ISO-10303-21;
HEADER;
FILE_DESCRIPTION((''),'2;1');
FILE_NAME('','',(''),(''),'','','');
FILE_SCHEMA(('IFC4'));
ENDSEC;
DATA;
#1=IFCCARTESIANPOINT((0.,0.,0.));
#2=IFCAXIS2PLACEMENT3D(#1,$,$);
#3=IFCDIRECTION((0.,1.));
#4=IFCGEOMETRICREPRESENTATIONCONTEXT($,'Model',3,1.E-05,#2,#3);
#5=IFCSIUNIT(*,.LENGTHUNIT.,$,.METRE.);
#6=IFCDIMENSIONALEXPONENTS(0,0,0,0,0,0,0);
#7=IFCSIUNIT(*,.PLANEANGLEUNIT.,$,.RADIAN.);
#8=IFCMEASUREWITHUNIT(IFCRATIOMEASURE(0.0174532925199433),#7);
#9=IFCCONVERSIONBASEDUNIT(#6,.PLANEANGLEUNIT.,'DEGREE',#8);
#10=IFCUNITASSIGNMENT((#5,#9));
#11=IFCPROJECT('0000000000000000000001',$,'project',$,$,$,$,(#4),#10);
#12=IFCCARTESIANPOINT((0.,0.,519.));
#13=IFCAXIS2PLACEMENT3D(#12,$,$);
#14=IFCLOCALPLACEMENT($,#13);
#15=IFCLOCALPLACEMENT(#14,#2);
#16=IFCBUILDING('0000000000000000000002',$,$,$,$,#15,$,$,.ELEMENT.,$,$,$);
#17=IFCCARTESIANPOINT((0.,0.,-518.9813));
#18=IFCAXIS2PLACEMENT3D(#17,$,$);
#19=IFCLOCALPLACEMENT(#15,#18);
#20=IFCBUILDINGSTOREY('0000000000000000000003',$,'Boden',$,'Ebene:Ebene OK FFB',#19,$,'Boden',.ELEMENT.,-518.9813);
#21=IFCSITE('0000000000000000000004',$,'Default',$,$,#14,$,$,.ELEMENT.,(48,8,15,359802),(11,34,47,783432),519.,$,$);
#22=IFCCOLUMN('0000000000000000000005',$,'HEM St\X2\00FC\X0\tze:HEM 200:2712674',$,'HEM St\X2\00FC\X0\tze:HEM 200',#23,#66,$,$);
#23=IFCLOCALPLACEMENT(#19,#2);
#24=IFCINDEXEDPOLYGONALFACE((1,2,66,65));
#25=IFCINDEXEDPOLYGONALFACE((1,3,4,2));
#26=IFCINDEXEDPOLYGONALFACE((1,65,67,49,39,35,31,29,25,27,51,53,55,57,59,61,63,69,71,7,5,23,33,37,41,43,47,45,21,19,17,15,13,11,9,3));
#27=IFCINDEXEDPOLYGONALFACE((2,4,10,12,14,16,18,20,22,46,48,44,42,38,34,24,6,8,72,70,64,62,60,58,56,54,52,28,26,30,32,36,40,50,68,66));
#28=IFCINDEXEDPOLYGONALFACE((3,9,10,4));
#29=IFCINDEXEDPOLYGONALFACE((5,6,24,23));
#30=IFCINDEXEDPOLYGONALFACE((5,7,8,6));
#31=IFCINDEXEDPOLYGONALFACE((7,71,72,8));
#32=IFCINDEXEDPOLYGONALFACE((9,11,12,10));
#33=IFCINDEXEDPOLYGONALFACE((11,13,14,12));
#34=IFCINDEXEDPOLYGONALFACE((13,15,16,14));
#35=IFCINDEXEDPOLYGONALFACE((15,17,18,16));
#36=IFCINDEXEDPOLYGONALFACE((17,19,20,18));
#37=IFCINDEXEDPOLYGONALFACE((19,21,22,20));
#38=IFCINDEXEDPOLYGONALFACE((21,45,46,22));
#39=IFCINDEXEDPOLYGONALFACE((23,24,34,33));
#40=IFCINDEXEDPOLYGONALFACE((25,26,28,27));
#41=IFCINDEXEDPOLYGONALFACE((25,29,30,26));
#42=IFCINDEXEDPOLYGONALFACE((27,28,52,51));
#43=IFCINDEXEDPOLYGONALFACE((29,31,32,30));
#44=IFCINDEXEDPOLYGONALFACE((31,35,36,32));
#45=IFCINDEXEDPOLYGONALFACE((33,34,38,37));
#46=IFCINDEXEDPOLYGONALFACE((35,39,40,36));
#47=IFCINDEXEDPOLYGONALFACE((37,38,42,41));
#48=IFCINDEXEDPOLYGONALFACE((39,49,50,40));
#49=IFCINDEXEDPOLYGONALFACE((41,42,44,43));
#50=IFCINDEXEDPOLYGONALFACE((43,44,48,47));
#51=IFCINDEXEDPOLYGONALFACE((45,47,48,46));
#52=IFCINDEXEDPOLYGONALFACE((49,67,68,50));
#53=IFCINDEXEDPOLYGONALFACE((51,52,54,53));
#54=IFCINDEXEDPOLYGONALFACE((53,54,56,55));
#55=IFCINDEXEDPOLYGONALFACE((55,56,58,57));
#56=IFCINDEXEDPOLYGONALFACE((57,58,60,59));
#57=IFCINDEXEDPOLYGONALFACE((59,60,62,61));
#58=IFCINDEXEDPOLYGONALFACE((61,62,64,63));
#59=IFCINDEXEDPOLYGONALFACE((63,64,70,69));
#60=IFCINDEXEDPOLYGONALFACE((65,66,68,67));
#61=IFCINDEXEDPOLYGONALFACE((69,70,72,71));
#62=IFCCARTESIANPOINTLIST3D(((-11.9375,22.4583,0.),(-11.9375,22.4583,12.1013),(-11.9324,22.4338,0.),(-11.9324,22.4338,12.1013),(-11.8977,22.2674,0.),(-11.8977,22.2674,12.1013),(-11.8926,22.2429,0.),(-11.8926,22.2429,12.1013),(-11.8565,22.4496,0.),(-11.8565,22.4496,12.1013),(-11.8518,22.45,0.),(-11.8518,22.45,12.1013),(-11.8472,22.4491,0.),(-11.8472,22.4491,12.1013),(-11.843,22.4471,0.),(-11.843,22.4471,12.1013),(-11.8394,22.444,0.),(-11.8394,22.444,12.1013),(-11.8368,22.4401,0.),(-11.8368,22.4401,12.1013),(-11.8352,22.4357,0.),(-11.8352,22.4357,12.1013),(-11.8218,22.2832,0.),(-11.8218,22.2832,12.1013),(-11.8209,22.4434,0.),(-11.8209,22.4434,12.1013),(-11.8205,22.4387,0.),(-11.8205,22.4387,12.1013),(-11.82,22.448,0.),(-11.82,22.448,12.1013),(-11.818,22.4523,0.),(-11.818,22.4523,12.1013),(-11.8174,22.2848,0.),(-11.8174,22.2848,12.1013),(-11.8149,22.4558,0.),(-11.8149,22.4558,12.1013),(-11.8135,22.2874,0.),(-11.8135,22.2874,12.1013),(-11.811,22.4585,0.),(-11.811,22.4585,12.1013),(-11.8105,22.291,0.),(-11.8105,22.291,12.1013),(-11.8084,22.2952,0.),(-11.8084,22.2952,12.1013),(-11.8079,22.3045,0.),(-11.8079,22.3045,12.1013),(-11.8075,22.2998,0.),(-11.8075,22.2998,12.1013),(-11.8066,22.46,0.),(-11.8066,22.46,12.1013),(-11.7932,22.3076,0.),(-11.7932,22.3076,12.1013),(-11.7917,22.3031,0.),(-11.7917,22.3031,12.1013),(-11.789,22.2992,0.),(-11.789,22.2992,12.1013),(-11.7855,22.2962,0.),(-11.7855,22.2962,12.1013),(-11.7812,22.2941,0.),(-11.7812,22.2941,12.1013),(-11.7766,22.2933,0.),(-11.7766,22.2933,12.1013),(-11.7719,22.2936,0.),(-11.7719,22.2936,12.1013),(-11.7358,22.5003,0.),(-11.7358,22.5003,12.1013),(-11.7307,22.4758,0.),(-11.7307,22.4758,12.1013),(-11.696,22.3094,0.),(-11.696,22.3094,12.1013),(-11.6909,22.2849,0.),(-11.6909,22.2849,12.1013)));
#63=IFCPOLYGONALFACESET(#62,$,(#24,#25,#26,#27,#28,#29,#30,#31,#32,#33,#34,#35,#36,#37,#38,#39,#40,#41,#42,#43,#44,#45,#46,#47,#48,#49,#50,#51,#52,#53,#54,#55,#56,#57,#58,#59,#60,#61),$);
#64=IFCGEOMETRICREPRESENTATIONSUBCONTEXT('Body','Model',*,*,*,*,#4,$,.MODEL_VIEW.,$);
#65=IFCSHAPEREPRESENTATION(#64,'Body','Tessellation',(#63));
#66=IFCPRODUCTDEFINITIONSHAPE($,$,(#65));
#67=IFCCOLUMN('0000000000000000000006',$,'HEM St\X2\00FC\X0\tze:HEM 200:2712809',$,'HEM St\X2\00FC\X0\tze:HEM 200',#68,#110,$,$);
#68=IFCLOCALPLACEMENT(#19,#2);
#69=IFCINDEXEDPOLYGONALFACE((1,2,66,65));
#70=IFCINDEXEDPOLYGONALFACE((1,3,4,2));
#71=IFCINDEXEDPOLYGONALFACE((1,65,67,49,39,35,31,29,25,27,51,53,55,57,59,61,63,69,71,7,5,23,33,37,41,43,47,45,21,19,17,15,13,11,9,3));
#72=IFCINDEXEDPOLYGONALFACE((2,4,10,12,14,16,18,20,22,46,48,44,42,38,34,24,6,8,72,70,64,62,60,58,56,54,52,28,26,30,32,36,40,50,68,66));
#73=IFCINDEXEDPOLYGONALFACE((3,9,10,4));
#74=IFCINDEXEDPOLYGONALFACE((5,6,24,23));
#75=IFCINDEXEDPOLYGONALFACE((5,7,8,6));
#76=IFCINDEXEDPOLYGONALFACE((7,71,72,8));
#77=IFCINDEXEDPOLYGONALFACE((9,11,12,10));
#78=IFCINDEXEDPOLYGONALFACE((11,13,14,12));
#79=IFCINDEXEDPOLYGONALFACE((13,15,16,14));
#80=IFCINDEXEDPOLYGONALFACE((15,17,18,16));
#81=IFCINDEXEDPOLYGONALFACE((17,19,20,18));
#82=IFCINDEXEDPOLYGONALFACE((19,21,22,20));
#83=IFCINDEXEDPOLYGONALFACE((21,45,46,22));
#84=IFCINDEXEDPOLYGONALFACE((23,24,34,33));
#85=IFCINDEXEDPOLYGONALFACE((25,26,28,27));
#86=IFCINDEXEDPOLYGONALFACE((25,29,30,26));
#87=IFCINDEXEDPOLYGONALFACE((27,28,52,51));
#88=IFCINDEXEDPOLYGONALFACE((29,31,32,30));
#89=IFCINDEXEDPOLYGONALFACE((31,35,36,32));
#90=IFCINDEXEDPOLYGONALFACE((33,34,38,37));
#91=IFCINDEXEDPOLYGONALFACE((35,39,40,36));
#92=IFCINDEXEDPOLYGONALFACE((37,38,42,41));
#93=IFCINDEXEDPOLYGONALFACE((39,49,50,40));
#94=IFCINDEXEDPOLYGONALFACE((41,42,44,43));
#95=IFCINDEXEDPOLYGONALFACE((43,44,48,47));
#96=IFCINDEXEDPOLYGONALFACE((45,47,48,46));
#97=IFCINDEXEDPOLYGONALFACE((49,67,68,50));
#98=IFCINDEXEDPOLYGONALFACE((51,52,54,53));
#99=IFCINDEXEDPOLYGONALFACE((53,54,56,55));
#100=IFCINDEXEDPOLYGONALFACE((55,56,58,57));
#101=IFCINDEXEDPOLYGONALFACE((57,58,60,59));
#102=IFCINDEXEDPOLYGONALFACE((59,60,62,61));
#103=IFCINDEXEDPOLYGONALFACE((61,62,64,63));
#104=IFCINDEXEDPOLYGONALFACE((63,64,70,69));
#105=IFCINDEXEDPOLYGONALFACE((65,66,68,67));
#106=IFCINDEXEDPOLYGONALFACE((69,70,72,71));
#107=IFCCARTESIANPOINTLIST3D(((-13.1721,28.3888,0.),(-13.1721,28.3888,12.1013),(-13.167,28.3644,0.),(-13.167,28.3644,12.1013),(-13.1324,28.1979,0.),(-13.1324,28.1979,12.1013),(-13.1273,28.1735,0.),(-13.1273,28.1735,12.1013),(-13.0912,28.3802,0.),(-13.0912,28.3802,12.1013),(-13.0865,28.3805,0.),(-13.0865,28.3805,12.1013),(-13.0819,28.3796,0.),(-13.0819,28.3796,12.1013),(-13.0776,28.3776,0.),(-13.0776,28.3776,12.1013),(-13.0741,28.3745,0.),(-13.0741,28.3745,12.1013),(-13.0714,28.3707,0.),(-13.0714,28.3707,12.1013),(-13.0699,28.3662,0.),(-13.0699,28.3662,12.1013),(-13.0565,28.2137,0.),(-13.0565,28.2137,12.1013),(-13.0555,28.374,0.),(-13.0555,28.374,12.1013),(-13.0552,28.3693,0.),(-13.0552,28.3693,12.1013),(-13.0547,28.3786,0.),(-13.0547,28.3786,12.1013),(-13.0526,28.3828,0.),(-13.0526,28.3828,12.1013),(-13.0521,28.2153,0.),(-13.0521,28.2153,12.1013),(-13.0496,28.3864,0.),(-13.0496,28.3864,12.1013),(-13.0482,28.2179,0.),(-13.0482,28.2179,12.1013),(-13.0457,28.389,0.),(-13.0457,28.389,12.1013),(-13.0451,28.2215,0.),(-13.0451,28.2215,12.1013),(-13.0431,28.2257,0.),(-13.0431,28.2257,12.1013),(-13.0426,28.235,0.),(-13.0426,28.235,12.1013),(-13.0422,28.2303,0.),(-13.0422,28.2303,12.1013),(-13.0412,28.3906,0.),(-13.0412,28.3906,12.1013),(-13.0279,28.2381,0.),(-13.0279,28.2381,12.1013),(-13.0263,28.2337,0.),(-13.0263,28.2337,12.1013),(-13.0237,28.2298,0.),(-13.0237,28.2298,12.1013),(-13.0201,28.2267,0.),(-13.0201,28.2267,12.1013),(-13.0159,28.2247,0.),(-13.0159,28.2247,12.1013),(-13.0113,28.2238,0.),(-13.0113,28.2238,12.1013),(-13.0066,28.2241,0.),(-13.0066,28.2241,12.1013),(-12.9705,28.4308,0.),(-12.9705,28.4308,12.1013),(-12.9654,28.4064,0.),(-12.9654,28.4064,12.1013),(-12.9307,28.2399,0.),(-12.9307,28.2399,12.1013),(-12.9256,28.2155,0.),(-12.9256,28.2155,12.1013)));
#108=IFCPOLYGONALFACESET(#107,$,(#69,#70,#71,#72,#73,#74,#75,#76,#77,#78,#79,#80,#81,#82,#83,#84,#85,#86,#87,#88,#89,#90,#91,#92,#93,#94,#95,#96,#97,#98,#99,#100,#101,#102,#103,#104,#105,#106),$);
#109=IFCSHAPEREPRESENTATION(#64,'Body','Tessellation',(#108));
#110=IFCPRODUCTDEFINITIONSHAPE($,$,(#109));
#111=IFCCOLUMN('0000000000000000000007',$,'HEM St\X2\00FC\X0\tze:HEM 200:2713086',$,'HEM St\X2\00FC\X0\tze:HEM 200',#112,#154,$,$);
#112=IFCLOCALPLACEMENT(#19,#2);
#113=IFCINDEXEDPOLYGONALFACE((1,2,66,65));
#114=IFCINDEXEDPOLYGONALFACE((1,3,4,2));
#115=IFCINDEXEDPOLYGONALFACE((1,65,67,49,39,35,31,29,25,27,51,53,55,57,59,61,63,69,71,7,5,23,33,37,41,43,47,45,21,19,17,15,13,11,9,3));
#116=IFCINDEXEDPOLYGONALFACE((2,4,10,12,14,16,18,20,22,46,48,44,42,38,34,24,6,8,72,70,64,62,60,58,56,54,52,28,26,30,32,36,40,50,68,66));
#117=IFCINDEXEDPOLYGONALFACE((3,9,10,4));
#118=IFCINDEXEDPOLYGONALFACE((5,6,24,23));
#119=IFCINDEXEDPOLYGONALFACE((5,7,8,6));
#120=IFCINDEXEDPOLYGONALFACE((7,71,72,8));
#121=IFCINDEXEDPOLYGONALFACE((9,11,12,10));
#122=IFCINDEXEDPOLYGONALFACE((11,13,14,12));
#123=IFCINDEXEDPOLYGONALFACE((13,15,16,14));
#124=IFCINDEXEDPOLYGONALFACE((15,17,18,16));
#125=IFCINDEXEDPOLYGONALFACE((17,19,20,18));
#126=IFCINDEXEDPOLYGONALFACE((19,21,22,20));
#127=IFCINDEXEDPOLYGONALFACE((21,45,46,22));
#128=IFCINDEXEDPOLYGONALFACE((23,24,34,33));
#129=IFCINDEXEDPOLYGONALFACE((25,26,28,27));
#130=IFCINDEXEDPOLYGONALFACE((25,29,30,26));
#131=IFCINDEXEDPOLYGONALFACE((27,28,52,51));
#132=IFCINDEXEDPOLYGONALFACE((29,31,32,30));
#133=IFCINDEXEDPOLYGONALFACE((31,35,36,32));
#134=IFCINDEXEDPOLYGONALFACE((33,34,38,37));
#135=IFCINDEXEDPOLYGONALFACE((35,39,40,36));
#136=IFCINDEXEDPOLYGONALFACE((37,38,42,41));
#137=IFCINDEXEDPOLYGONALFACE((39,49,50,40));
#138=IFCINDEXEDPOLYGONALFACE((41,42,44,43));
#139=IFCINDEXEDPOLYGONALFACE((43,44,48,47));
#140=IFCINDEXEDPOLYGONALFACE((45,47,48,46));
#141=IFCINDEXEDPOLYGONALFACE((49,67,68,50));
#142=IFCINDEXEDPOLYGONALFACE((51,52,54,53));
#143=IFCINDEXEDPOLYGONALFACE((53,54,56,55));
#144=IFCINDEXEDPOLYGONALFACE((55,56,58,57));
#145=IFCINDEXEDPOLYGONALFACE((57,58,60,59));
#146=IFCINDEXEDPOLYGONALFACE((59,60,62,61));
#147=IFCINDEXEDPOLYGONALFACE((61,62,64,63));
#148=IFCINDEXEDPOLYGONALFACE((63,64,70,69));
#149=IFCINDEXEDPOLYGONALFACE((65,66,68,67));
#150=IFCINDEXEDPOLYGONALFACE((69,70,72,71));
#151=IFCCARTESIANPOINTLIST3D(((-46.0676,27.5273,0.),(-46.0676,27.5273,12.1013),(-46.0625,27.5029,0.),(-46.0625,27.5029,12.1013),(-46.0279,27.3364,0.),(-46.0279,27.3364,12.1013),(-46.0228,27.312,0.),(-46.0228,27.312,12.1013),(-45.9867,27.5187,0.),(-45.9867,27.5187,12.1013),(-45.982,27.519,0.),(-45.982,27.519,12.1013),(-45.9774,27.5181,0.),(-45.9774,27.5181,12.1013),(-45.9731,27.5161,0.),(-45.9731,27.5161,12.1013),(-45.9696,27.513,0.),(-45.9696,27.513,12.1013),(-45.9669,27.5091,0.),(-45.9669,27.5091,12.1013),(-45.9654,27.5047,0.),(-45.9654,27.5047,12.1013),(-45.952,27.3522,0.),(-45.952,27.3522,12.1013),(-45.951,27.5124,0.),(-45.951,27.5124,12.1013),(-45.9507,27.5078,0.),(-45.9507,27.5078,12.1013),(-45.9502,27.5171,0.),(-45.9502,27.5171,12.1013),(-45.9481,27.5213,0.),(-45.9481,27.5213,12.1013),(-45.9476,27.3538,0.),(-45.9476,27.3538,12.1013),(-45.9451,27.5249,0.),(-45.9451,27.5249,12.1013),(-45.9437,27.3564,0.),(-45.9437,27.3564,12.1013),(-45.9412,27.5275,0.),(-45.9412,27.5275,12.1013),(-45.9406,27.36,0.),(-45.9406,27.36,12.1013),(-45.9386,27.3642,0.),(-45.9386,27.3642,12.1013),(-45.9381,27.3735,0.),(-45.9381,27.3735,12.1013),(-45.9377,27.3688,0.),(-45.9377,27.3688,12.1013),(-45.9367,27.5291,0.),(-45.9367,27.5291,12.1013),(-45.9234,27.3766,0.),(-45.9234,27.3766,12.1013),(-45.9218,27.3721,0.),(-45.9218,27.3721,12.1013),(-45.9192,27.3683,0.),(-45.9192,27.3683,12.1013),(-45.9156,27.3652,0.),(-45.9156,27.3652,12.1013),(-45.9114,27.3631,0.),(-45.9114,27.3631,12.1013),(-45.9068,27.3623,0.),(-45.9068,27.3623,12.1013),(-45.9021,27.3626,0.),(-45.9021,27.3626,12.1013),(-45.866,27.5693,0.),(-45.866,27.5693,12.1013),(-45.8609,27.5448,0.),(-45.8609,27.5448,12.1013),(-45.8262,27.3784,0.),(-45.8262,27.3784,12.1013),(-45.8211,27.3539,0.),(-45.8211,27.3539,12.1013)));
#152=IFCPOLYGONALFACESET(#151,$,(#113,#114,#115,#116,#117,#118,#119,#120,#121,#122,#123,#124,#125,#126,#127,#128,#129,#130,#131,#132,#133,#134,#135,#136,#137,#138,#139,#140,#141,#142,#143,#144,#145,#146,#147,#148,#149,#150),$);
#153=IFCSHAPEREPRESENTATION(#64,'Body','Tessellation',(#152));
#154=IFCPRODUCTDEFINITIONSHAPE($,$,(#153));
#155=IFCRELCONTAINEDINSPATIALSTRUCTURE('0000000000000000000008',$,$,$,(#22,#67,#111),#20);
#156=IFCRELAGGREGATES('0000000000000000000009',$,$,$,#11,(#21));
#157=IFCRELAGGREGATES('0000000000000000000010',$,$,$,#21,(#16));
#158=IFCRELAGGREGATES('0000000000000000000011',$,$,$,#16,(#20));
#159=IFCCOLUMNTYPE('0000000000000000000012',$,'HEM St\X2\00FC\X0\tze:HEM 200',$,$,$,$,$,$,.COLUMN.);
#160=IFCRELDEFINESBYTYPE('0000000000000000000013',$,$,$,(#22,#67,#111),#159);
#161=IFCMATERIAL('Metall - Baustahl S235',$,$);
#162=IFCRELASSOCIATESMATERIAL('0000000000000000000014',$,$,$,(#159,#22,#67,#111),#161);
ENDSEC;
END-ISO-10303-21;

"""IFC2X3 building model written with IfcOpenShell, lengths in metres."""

from ifc_helpers import new_model, entity, si_unit, converted_unit, direction, frame, frame_2d, origin, place, context, subcontext, project, spatial, polyline, circle_curve, parameter, trimmed, segment, composite_curve, outline, extrude, source, transform, mapped, material, type_object, type_shapes, element, save


model = new_model("IFC2X3")

# Units and contexts
model_context = context("Model", 3, precision=1e-05, world=origin(), true_north=direction((0.0, 1.0)))
body_context = subcontext(model_context, "Body", "Model", "MODEL_VIEW")
ifc_project = project(units=[si_unit("LENGTHUNIT", "METRE"), converted_unit("PLANEANGLEUNIT", "DEGREE", entity("IfcRatioMeasure", 0.0174532925199433), si_unit("PLANEANGLEUNIT", "RADIAN"), dimensions=[0, 0, 0, 0, 0, 0, 0])], contexts=[model_context])

# Site, building, storey
site_placement = place(None, frame((0.0, 0.0, 519.0)))
site = spatial("IfcSite", under=ifc_project, at=site_placement, Name="Default", CompositionType="ELEMENT", RefLatitude=(48, 8, 15, 359802), RefLongitude=(11, 34, 47, 783432), RefElevation=519.0)
building_placement = place(site_placement, origin())
building = spatial("IfcBuilding", under=site, at=building_placement, CompositionType="ELEMENT")
storey_placement = place(building_placement, frame((0.0, 0.0, -518.9813)))
storey = spatial("IfcBuildingStorey", under=building, at=storey_placement, Name="Boden", ObjectType="Ebene:Ebene OK FFB", LongName="Boden", CompositionType="ELEMENT", Elevation=-518.9813)

# Columns
ifc_material_1 = material(Name="Metall - Baustahl S235")
column_type_1 = type_object("IfcColumnType", Name="HEM Stütze:HEM 200", PredefinedType="COLUMN", material=ifc_material_1)
shared_shape_1 = source(origin(), body_context, "Body", "SweptSolid", [
    extrude(outline(composite_curve([segment(polyline([(0.085, -0.103), (0.11, -0.103)]), True, "CONTINUOUS"), segment(polyline([(0.11, -0.103), (0.11, 0.103)]), True, "CONTINUOUS"), segment(polyline([(0.11, 0.103), (0.085, 0.103)]), True, "CONTINUOUS"), segment(polyline([(0.085, 0.103), (0.085, 0.0255)]), True, "CONTINUOUS"), segment(trimmed(circle_curve(frame_2d((0.067, 0.0255), x_axis=(1.0, 0.0)), 0.018), [parameter(270.0)], [parameter(0.0)], True, "PARAMETER"), False, "CONTINUOUS"), segment(polyline([(0.067, 0.0075), (-0.067, 0.0075)]), True, "CONTINUOUS"), segment(trimmed(circle_curve(frame_2d((-0.067, 0.0255), x_axis=(0.0, -1.0)), 0.018), [parameter(270.0)], [parameter(0.0)], True, "PARAMETER"), False, "CONTINUOUS"), segment(polyline([(-0.085, 0.0255), (-0.085, 0.103)]), True, "CONTINUOUS"), segment(polyline([(-0.085, 0.103), (-0.11, 0.103)]), True, "CONTINUOUS"), segment(polyline([(-0.11, 0.103), (-0.11, -0.103)]), True, "CONTINUOUS"), segment(polyline([(-0.11, -0.103), (-0.085, -0.103)]), True, "CONTINUOUS"), segment(polyline([(-0.085, -0.103), (-0.085, -0.0255)]), True, "CONTINUOUS"), segment(trimmed(circle_curve(frame_2d((-0.067, -0.0255), x_axis=(-1.0, 0.0)), 0.018), [parameter(270.0)], [parameter(0.0)], True, "PARAMETER"), False, "CONTINUOUS"), segment(polyline([(-0.067, -0.0075), (0.067, -0.0075)]), True, "CONTINUOUS"), segment(trimmed(circle_curve(frame_2d((0.067, -0.0255), x_axis=(0.0, 1.0)), 0.018), [parameter(270.0)], [parameter(0.0)], True, "PARAMETER"), False, "CONTINUOUS"), segment(polyline([(0.085, -0.0255), (0.085, -0.103)]), True, "CONTINUOUS")], self_intersect=False)), frame((0.0, 0.0, -518.9813), z_axis=(0.0, 0.0, 1.0), x_axis=(0.0, -1.0, 0.0)), (0.0, 0.0, 1.0), 12.1013),
])
type_shapes(column_type_1, [shared_shape_1])
for number, where, z_axis, x_axis, name in (
    (1, (-11.8142, 22.3716, 518.9813), (0.0, 0.0, 1.0), (0.979008, 0.20382, 0.0), "HEM Stütze:HEM 200:2712674"),
    (2, (-13.0489, 28.3022, 518.9813), (0.0, 0.0, 1.0), (0.979008, 0.20382, 0.0), "HEM Stütze:HEM 200:2712809"),
    (3, (-45.9444, 27.4406, 518.9813), (0.0, 0.0, 1.0), (0.979008, 0.20382, 0.0), "HEM Stütze:HEM 200:2713086"),
):
    element("IfcColumn", number, at=place(storey_placement, frame(where, z_axis=z_axis, x_axis=x_axis)), inside=storey, type_object=column_type_1, material=ifc_material_1, Name=name, ObjectType="HEM Stütze:HEM 200", context=body_context, shape_type="MappedRepresentation", body=[
        mapped(shared_shape_1, transform((0.0, 0.0, 0.0), scale=1.0)),
    ])

save(model, "model.ifc")
